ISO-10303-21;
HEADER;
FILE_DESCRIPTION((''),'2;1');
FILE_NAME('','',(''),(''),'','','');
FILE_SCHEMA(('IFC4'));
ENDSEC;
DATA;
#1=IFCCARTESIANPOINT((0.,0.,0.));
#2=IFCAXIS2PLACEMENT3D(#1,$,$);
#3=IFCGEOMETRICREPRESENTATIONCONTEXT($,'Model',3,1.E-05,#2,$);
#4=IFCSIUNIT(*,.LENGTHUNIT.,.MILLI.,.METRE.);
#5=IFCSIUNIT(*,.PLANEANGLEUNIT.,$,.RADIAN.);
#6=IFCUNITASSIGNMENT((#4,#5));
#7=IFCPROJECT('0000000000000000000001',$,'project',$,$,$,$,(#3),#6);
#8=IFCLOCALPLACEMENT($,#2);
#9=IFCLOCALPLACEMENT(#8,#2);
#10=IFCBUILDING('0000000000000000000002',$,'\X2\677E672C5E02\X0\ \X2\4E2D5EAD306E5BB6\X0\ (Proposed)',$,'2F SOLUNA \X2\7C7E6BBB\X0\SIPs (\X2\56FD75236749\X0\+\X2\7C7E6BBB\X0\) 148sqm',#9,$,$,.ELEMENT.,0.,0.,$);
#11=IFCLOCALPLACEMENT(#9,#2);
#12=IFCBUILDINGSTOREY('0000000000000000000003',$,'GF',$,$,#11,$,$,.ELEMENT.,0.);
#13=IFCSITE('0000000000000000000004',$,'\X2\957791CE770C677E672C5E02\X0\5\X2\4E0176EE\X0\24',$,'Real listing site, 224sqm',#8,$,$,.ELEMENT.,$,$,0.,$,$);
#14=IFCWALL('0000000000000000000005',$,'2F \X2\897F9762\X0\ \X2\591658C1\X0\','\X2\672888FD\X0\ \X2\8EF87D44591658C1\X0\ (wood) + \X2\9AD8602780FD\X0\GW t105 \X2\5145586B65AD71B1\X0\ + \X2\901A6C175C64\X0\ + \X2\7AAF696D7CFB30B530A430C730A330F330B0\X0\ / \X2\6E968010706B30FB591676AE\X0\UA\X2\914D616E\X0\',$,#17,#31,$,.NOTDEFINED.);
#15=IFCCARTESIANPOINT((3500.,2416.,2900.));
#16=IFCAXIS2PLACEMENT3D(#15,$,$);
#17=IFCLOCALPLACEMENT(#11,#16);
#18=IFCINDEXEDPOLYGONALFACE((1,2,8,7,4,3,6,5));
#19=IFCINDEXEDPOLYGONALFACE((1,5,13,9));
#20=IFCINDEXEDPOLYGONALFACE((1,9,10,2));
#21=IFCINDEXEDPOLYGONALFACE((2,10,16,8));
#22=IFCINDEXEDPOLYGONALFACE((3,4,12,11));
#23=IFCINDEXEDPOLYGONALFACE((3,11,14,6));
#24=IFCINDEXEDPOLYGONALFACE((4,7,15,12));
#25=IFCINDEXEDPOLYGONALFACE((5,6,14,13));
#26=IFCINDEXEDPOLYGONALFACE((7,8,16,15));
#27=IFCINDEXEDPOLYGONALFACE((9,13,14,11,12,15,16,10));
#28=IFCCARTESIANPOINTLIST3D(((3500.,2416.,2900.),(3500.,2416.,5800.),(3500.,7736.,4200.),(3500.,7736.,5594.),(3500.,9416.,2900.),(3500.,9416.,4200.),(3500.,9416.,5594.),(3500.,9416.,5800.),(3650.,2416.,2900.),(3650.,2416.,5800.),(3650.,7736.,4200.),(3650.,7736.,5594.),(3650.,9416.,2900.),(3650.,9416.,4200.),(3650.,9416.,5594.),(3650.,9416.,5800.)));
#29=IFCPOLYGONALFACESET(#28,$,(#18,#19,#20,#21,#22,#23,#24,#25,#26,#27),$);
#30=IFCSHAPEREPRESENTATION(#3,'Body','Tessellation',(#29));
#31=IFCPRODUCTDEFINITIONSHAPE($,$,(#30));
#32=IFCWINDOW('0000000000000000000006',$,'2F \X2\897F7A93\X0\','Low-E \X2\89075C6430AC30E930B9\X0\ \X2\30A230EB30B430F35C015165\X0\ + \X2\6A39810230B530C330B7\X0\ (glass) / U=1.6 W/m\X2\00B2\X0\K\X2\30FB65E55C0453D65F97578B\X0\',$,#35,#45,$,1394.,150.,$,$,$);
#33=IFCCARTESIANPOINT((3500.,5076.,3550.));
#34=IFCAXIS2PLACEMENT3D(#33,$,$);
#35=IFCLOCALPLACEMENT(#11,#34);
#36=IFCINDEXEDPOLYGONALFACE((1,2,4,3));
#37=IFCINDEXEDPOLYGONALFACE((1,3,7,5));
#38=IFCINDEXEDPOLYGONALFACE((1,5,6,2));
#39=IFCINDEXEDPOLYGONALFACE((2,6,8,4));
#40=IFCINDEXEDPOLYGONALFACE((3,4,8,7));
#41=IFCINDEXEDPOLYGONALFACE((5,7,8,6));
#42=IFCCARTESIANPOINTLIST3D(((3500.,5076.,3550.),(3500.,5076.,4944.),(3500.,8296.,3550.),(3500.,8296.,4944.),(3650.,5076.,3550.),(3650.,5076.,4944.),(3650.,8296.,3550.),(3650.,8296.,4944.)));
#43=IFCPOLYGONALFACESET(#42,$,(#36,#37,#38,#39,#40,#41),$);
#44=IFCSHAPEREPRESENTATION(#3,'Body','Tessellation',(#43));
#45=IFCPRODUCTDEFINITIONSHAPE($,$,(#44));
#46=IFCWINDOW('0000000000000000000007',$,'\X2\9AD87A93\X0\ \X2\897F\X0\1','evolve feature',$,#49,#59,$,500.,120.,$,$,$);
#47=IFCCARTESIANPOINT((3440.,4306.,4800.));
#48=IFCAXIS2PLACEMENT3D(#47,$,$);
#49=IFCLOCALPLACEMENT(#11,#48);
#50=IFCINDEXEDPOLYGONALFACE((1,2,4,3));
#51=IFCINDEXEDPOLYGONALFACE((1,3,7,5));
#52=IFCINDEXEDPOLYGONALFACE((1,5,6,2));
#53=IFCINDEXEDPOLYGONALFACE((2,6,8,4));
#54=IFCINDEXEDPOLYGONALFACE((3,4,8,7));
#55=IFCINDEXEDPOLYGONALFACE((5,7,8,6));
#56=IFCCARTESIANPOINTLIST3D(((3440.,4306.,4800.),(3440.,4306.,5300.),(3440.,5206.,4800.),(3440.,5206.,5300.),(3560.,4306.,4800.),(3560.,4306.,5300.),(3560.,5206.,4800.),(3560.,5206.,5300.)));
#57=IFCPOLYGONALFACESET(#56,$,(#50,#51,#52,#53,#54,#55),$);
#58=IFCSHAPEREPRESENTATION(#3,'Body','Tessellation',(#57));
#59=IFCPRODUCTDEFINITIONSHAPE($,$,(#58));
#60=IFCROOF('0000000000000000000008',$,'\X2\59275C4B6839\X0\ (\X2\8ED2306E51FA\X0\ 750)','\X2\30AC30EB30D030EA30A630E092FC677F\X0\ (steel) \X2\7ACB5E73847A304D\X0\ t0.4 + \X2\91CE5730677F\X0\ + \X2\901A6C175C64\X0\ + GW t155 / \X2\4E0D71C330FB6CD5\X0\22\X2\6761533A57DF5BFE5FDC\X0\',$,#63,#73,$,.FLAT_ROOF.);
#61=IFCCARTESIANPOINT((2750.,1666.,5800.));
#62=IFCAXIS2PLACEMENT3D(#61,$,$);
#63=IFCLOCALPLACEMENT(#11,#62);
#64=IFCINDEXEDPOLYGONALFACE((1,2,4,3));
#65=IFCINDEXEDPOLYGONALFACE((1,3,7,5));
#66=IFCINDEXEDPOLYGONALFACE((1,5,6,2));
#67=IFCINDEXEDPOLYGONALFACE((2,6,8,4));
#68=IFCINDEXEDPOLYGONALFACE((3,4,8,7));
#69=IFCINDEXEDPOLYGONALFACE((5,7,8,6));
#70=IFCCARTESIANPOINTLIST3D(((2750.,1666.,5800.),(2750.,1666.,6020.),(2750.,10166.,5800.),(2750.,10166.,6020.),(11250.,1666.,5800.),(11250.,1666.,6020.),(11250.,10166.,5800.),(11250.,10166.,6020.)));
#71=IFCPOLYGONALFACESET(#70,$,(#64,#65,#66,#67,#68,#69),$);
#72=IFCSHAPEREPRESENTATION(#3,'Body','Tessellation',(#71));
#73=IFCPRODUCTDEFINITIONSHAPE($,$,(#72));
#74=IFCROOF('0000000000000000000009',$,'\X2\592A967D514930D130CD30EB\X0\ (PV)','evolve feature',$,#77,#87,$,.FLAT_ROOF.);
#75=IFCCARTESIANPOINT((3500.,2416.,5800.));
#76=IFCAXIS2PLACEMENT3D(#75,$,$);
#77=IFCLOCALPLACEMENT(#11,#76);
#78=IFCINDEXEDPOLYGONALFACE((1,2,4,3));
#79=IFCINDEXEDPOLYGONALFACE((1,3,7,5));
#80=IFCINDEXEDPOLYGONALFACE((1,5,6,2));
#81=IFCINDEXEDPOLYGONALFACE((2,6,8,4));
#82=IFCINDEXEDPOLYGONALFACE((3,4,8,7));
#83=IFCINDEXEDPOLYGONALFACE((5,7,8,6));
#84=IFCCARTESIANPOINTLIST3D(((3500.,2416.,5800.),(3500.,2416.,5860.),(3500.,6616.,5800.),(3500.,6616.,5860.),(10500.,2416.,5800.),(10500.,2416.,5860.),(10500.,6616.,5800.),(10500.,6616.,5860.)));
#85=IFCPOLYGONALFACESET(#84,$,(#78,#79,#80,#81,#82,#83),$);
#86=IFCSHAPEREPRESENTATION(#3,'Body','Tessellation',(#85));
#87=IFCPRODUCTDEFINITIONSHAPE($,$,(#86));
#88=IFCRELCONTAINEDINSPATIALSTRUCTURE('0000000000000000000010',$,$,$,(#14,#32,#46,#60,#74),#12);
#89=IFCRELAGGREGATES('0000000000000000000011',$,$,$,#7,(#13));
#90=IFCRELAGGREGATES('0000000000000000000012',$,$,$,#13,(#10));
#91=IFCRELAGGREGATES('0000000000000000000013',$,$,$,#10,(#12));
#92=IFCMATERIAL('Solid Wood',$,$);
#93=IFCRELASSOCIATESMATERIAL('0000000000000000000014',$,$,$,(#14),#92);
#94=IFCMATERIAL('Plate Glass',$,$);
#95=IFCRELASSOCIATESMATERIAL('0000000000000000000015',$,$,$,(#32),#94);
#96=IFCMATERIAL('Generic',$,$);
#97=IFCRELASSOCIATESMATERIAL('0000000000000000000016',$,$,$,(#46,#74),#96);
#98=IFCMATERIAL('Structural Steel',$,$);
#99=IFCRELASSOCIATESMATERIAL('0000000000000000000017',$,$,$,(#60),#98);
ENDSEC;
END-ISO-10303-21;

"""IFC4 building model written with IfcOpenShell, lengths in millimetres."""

from ifc_helpers import new_model, si_unit, frame, frame_2d, origin, place, context, project, spatial, rectangle, extrude, material, element, fill, save


model = new_model("IFC4")

# Units and contexts
model_context = context("Model", 3, precision=1e-05, world=origin())
ifc_project = project(units=[si_unit("LENGTHUNIT", "METRE", prefix="MILLI"), si_unit("PLANEANGLEUNIT", "RADIAN")], contexts=[model_context])

# Site, building, storey
site_placement = place(None, origin())
site = spatial("IfcSite", under=ifc_project, at=site_placement, Name="長野県松本市5丁目24", ObjectType="Real listing site, 224sqm", CompositionType="ELEMENT", RefElevation=0.0)
building_placement = place(site_placement, origin())
building = spatial("IfcBuilding", under=site, at=building_placement, Name="松本市 中庭の家 (Proposed)", ObjectType="2F SOLUNA 籾殻SIPs (国産杉+籾殻) 148sqm", CompositionType="ELEMENT", ElevationOfRefHeight=0.0, ElevationOfTerrain=0.0)
storey_placement = place(building_placement, origin())
storey = spatial("IfcBuildingStorey", under=building, at=storey_placement, Name="GF", CompositionType="ELEMENT", Elevation=0.0)

# Shared definitions
ifc_material_1 = material(Name="Solid Wood")
ifc_material_2 = material(Name="Generic")

# Shared definitions
ifc_material_3 = material(Name="Plate Glass")

# Wall, openings, windows
wall_1_placement = place(storey_placement, frame((3500.0, 2416.0, 2900.0)))
wall_1 = element("IfcWall", 1, at=wall_1_placement, inside=storey, material=ifc_material_1, Name="2F 西面 外壁", Description="木製 軸組外壁 (wood) + 高性能GW t105 充填断熱 + 通気層 + 窯業系サイディング / 準耐火・外皮UA配慮", PredefinedType="NOTDEFINED", context=model_context, shape_type="SweptSolid", body=[
    extrude(rectangle(XDim=150.0, YDim=7000.0, at=frame_2d((75.0, 3500.0))), frame((3500.0, 2416.0, 2900.0)), (0.0, 0.0, 1.0), 2900.0),
])
opening_1_placement = place(storey_placement, frame((3500.0, 5076.0, 3550.0)))
opening_1 = element("IfcOpeningElement", 2, at=opening_1_placement, cuts=wall_1, PredefinedType="NOTDEFINED", context=model_context, shape_type="SweptSolid", body=[
    extrude(rectangle(XDim=150.0, YDim=3220.0, at=frame_2d((75.0, 1610.0))), frame((3500.0, 5076.0, 3550.0)), (0.0, 0.0, 1.0), 1394.0),
])
opening_2_placement = place(storey_placement, frame((3440.0, 4306.0, 4800.0)))
opening_2 = element("IfcOpeningElement", 3, at=opening_2_placement, cuts=wall_1, PredefinedType="NOTDEFINED", context=model_context, shape_type="SweptSolid", body=[
    extrude(rectangle(XDim=120.0, YDim=900.0, at=frame_2d((60.0, 450.0))), frame((3440.0, 4306.0, 4800.0)), (0.0, 0.0, 1.0), 500.0),
])
window_1_placement = place(storey_placement, frame((3500.0, 5076.0, 3550.0)))
window_1 = element("IfcWindow", 4, at=window_1_placement, inside=storey, material=ifc_material_3, Name="2F 西窓", Description="Low-E 複層ガラス アルゴン封入 + 樹脂サッシ (glass) / U=1.6 W/m²K・日射取得型", OverallHeight=1394.0, OverallWidth=150.0, context=model_context, shape_type="SweptSolid", body=[
    extrude(rectangle(XDim=150.0, YDim=3220.0, at=frame_2d((75.0, 1610.0))), frame((3500.0, 5076.0, 3550.0)), (0.0, 0.0, 1.0), 1394.0),
])
fill(opening_1, window_1)
window_2_placement = place(storey_placement, frame((3440.0, 4306.0, 4800.0)))
window_2 = element("IfcWindow", 5, at=window_2_placement, inside=storey, material=ifc_material_2, Name="高窓 西1", Description="evolve feature", OverallHeight=500.0, OverallWidth=120.0, context=model_context, shape_type="SweptSolid", body=[
    extrude(rectangle(XDim=120.0, YDim=900.0, at=frame_2d((60.0, 450.0))), frame((3440.0, 4306.0, 4800.0)), (0.0, 0.0, 1.0), 500.0),
])
fill(opening_2, window_2)

# Roofs
ifc_material_4 = material(Name="Structural Steel")
roof_1_placement = place(storey_placement, frame((2750.0, 1666.0, 5800.0)))
element("IfcRoof", 6, at=roof_1_placement, inside=storey, material=ifc_material_4, Name="大屋根 (軒の出 750)", Description="ガルバリウム鋼板 (steel) 立平葺き t0.4 + 野地板 + 通気層 + GW t155 / 不燃・法22条区域対応", PredefinedType="FLAT_ROOF", context=model_context, shape_type="SweptSolid", body=[
    extrude(rectangle(XDim=8500.0, YDim=8500.0, at=frame_2d((4250.0, 4250.0))), frame((2750.0, 1666.0, 5800.0)), (0.0, 0.0, 1.0), 220.0),
])
roof_2_placement = place(storey_placement, frame((3500.0, 2416.0, 5800.0)))
element("IfcRoof", 7, at=roof_2_placement, inside=storey, material=ifc_material_2, Name="太陽光パネル (PV)", Description="evolve feature", PredefinedType="FLAT_ROOF", context=model_context, shape_type="SweptSolid", body=[
    extrude(rectangle(XDim=7000.0, YDim=4200.0, at=frame_2d((3500.0, 2100.0))), frame((3500.0, 2416.0, 5800.0)), (0.0, 0.0, 1.0), 60.0),
])

save(model, "model.ifc")
